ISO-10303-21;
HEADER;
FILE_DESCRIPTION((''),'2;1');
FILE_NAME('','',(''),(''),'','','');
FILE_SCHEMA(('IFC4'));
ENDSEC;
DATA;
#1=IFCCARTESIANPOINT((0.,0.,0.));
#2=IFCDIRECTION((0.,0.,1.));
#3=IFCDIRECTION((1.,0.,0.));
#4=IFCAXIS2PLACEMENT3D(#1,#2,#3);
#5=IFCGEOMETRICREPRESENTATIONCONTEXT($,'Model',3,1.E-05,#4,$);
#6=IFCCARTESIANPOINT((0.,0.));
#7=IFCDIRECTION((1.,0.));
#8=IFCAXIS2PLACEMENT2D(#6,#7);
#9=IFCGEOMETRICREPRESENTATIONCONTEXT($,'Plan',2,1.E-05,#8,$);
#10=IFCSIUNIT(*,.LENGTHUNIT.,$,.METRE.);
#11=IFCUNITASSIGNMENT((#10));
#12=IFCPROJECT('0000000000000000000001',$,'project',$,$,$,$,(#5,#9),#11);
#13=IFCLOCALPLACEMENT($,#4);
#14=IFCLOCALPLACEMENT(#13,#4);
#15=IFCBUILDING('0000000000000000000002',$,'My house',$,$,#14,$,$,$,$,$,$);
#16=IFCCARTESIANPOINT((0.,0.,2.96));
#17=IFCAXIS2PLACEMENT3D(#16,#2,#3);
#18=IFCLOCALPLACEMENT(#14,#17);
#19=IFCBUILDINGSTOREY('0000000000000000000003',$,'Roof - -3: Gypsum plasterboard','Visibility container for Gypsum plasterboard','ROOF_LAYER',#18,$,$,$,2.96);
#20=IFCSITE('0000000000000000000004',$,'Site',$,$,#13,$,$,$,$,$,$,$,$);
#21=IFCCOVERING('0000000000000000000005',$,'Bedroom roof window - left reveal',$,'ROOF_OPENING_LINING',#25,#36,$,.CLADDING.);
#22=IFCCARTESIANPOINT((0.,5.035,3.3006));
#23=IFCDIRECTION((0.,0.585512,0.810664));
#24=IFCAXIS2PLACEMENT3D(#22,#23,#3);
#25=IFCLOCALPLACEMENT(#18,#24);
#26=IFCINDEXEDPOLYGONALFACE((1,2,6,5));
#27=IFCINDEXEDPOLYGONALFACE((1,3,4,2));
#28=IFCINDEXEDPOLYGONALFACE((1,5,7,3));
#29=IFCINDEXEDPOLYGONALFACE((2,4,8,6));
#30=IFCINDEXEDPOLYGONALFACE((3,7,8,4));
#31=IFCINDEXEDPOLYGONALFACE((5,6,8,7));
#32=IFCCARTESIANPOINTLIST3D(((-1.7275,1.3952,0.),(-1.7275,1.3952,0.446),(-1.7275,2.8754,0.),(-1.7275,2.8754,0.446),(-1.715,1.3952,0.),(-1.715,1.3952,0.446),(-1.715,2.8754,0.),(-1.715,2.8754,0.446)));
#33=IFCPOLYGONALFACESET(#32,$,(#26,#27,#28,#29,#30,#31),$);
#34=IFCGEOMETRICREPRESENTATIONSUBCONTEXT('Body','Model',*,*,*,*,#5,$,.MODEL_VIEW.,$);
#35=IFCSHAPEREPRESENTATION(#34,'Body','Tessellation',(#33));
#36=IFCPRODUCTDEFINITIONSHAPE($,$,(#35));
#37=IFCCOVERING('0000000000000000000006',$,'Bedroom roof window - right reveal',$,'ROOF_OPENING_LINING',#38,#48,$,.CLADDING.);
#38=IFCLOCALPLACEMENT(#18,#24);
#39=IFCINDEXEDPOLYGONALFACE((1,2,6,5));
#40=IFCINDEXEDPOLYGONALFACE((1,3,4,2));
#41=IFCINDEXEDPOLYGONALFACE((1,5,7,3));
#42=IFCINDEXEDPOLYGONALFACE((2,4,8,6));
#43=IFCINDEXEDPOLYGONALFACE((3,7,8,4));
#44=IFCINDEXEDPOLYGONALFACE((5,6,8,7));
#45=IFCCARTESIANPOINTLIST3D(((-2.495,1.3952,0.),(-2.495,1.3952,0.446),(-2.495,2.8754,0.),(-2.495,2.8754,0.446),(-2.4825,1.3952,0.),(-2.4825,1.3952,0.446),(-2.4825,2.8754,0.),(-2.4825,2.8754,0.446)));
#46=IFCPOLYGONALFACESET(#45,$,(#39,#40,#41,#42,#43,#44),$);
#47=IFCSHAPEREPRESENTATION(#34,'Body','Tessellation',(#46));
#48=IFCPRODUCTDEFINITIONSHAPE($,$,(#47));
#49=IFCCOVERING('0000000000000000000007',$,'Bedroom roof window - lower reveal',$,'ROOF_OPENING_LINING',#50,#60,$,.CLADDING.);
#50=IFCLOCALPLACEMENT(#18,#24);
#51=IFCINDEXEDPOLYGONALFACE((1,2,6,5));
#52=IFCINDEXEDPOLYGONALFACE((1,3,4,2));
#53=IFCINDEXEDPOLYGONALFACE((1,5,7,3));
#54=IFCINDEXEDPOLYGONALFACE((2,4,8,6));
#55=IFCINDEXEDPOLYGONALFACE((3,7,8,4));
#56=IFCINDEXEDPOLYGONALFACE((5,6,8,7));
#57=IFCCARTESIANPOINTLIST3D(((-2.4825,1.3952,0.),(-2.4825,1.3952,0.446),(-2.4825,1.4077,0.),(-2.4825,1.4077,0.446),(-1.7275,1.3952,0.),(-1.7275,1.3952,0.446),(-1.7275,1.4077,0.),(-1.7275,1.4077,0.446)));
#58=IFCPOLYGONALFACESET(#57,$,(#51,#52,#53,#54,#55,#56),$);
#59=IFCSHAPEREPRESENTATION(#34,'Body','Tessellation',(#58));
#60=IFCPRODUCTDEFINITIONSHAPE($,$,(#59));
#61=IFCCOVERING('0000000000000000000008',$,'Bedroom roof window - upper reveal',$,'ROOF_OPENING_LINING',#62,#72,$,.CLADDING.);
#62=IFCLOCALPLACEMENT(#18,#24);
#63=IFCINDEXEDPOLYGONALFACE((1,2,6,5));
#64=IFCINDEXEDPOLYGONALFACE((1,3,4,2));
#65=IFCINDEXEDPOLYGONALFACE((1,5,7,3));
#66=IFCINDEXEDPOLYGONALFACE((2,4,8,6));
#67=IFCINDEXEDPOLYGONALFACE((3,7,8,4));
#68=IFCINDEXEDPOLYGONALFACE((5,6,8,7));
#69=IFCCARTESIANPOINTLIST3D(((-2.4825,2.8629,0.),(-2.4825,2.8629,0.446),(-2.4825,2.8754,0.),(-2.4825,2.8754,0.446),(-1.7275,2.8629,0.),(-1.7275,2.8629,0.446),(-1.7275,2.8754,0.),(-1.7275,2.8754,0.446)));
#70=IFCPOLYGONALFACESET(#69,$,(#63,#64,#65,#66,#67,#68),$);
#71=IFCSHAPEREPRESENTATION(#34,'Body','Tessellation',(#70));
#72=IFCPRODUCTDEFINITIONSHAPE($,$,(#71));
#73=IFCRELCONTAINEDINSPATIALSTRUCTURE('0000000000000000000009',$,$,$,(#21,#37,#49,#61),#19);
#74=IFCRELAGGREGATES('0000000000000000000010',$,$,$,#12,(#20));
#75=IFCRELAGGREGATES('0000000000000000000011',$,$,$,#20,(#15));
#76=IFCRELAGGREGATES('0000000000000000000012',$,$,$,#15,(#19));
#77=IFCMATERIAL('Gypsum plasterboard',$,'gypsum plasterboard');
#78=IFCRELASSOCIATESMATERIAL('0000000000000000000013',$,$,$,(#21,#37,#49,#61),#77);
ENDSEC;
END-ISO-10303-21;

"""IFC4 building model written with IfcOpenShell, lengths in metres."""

from ifc_helpers import new_model, si_unit, frame, origin_with_axes, origin_2d_with_axis, place, context, subcontext, project, spatial, indexed_curve, outline, extrude, source, transform, mapped, material, element, save


model = new_model("IFC4")

# Units and contexts
model_context = context("Model", 3, precision=1e-05, world=origin_with_axes())
plan_context = context("Plan", 2, precision=1e-05, world=origin_2d_with_axis())
body_context = subcontext(model_context, "Body", "Model", "MODEL_VIEW")
ifc_project = project(units=[si_unit("LENGTHUNIT", "METRE")], contexts=[model_context, plan_context])

# Site, building, storey
site_placement = place(None, origin_with_axes())
site = spatial("IfcSite", under=ifc_project, at=site_placement, Name="Site")
building_placement = place(site_placement, origin_with_axes())
building = spatial("IfcBuilding", under=site, at=building_placement, Name="My house")
storey_placement = place(building_placement, frame((0.0, 0.0, 2.96), z_axis=(0.0, 0.0, 1.0), x_axis=(1.0, 0.0, 0.0)))
storey = spatial("IfcBuildingStorey", under=building, at=storey_placement, Name="Roof - -3: Gypsum plasterboard", Description="Visibility container for Gypsum plasterboard", ObjectType="ROOF_LAYER", Elevation=2.96)

# Shared definitions
ifc_material = material(Name="Gypsum plasterboard", Category="gypsum plasterboard")

# Coverings
shared_shape_1 = source(origin_with_axes(), body_context, "Body", "SweptSolid", [
    extrude(outline(indexed_curve([(1.715, 1.3952), (1.7275, 1.3952), (1.7275, 2.8754), (1.715, 2.8754)])), None, (0.0, 0.0, 1.0), 0.446),
])
covering_1_placement = place(storey_placement, frame((0.0, 5.035, 3.3006), z_axis=(0.0, 0.585512, 0.810664), x_axis=(1.0, 0.0, 0.0)))
element("IfcCovering", 1, at=covering_1_placement, inside=storey, material=ifc_material, Name="Bedroom roof window - left reveal", ObjectType="ROOF_OPENING_LINING", PredefinedType="CLADDING", context=body_context, shape_type="MappedRepresentation", body=[
    mapped(shared_shape_1, transform((0.0, 0.0, 0.0), x_axis=(-1.0, 0.0, 0.0), y_axis=(0.0, 1.0, 0.0), z_axis=(0.0, 0.0, 1.0), scale=1.0)),
])
shared_shape_2 = source(origin_with_axes(), body_context, "Body", "SweptSolid", [
    extrude(outline(indexed_curve([(2.4825, 1.3952), (2.495, 1.3952), (2.495, 2.8754), (2.4825, 2.8754)])), None, (0.0, 0.0, 1.0), 0.446),
])
covering_2_placement = place(storey_placement, frame((0.0, 5.035, 3.3006), z_axis=(0.0, 0.585512, 0.810664), x_axis=(1.0, 0.0, 0.0)))
element("IfcCovering", 2, at=covering_2_placement, inside=storey, material=ifc_material, Name="Bedroom roof window - right reveal", ObjectType="ROOF_OPENING_LINING", PredefinedType="CLADDING", context=body_context, shape_type="MappedRepresentation", body=[
    mapped(shared_shape_2, transform((0.0, 0.0, 0.0), x_axis=(-1.0, 0.0, 0.0), y_axis=(0.0, 1.0, 0.0), z_axis=(0.0, 0.0, 1.0), scale=1.0)),
])
shared_shape_3 = source(origin_with_axes(), body_context, "Body", "SweptSolid", [
    extrude(outline(indexed_curve([(1.7275, 1.3952), (2.4825, 1.3952), (2.4825, 1.4077), (1.7275, 1.4077)])), None, (0.0, 0.0, 1.0), 0.446),
])
covering_3_placement = place(storey_placement, frame((0.0, 5.035, 3.3006), z_axis=(0.0, 0.585512, 0.810664), x_axis=(1.0, 0.0, 0.0)))
element("IfcCovering", 3, at=covering_3_placement, inside=storey, material=ifc_material, Name="Bedroom roof window - lower reveal", ObjectType="ROOF_OPENING_LINING", PredefinedType="CLADDING", context=body_context, shape_type="MappedRepresentation", body=[
    mapped(shared_shape_3, transform((0.0, 0.0, 0.0), x_axis=(-1.0, 0.0, 0.0), y_axis=(0.0, 1.0, 0.0), z_axis=(0.0, 0.0, 1.0), scale=1.0)),
])
shared_shape_4 = source(origin_with_axes(), body_context, "Body", "SweptSolid", [
    extrude(outline(indexed_curve([(1.7275, 2.8629), (2.4825, 2.8629), (2.4825, 2.8754), (1.7275, 2.8754)])), None, (0.0, 0.0, 1.0), 0.446),
])
covering_4_placement = place(storey_placement, frame((0.0, 5.035, 3.3006), z_axis=(0.0, 0.585512, 0.810664), x_axis=(1.0, 0.0, 0.0)))
element("IfcCovering", 4, at=covering_4_placement, inside=storey, material=ifc_material, Name="Bedroom roof window - upper reveal", ObjectType="ROOF_OPENING_LINING", PredefinedType="CLADDING", context=body_context, shape_type="MappedRepresentation", body=[
    mapped(shared_shape_4, transform((0.0, 0.0, 0.0), x_axis=(-1.0, 0.0, 0.0), y_axis=(0.0, 1.0, 0.0), z_axis=(0.0, 0.0, 1.0), scale=1.0)),
])

save(model, "model.ifc")
